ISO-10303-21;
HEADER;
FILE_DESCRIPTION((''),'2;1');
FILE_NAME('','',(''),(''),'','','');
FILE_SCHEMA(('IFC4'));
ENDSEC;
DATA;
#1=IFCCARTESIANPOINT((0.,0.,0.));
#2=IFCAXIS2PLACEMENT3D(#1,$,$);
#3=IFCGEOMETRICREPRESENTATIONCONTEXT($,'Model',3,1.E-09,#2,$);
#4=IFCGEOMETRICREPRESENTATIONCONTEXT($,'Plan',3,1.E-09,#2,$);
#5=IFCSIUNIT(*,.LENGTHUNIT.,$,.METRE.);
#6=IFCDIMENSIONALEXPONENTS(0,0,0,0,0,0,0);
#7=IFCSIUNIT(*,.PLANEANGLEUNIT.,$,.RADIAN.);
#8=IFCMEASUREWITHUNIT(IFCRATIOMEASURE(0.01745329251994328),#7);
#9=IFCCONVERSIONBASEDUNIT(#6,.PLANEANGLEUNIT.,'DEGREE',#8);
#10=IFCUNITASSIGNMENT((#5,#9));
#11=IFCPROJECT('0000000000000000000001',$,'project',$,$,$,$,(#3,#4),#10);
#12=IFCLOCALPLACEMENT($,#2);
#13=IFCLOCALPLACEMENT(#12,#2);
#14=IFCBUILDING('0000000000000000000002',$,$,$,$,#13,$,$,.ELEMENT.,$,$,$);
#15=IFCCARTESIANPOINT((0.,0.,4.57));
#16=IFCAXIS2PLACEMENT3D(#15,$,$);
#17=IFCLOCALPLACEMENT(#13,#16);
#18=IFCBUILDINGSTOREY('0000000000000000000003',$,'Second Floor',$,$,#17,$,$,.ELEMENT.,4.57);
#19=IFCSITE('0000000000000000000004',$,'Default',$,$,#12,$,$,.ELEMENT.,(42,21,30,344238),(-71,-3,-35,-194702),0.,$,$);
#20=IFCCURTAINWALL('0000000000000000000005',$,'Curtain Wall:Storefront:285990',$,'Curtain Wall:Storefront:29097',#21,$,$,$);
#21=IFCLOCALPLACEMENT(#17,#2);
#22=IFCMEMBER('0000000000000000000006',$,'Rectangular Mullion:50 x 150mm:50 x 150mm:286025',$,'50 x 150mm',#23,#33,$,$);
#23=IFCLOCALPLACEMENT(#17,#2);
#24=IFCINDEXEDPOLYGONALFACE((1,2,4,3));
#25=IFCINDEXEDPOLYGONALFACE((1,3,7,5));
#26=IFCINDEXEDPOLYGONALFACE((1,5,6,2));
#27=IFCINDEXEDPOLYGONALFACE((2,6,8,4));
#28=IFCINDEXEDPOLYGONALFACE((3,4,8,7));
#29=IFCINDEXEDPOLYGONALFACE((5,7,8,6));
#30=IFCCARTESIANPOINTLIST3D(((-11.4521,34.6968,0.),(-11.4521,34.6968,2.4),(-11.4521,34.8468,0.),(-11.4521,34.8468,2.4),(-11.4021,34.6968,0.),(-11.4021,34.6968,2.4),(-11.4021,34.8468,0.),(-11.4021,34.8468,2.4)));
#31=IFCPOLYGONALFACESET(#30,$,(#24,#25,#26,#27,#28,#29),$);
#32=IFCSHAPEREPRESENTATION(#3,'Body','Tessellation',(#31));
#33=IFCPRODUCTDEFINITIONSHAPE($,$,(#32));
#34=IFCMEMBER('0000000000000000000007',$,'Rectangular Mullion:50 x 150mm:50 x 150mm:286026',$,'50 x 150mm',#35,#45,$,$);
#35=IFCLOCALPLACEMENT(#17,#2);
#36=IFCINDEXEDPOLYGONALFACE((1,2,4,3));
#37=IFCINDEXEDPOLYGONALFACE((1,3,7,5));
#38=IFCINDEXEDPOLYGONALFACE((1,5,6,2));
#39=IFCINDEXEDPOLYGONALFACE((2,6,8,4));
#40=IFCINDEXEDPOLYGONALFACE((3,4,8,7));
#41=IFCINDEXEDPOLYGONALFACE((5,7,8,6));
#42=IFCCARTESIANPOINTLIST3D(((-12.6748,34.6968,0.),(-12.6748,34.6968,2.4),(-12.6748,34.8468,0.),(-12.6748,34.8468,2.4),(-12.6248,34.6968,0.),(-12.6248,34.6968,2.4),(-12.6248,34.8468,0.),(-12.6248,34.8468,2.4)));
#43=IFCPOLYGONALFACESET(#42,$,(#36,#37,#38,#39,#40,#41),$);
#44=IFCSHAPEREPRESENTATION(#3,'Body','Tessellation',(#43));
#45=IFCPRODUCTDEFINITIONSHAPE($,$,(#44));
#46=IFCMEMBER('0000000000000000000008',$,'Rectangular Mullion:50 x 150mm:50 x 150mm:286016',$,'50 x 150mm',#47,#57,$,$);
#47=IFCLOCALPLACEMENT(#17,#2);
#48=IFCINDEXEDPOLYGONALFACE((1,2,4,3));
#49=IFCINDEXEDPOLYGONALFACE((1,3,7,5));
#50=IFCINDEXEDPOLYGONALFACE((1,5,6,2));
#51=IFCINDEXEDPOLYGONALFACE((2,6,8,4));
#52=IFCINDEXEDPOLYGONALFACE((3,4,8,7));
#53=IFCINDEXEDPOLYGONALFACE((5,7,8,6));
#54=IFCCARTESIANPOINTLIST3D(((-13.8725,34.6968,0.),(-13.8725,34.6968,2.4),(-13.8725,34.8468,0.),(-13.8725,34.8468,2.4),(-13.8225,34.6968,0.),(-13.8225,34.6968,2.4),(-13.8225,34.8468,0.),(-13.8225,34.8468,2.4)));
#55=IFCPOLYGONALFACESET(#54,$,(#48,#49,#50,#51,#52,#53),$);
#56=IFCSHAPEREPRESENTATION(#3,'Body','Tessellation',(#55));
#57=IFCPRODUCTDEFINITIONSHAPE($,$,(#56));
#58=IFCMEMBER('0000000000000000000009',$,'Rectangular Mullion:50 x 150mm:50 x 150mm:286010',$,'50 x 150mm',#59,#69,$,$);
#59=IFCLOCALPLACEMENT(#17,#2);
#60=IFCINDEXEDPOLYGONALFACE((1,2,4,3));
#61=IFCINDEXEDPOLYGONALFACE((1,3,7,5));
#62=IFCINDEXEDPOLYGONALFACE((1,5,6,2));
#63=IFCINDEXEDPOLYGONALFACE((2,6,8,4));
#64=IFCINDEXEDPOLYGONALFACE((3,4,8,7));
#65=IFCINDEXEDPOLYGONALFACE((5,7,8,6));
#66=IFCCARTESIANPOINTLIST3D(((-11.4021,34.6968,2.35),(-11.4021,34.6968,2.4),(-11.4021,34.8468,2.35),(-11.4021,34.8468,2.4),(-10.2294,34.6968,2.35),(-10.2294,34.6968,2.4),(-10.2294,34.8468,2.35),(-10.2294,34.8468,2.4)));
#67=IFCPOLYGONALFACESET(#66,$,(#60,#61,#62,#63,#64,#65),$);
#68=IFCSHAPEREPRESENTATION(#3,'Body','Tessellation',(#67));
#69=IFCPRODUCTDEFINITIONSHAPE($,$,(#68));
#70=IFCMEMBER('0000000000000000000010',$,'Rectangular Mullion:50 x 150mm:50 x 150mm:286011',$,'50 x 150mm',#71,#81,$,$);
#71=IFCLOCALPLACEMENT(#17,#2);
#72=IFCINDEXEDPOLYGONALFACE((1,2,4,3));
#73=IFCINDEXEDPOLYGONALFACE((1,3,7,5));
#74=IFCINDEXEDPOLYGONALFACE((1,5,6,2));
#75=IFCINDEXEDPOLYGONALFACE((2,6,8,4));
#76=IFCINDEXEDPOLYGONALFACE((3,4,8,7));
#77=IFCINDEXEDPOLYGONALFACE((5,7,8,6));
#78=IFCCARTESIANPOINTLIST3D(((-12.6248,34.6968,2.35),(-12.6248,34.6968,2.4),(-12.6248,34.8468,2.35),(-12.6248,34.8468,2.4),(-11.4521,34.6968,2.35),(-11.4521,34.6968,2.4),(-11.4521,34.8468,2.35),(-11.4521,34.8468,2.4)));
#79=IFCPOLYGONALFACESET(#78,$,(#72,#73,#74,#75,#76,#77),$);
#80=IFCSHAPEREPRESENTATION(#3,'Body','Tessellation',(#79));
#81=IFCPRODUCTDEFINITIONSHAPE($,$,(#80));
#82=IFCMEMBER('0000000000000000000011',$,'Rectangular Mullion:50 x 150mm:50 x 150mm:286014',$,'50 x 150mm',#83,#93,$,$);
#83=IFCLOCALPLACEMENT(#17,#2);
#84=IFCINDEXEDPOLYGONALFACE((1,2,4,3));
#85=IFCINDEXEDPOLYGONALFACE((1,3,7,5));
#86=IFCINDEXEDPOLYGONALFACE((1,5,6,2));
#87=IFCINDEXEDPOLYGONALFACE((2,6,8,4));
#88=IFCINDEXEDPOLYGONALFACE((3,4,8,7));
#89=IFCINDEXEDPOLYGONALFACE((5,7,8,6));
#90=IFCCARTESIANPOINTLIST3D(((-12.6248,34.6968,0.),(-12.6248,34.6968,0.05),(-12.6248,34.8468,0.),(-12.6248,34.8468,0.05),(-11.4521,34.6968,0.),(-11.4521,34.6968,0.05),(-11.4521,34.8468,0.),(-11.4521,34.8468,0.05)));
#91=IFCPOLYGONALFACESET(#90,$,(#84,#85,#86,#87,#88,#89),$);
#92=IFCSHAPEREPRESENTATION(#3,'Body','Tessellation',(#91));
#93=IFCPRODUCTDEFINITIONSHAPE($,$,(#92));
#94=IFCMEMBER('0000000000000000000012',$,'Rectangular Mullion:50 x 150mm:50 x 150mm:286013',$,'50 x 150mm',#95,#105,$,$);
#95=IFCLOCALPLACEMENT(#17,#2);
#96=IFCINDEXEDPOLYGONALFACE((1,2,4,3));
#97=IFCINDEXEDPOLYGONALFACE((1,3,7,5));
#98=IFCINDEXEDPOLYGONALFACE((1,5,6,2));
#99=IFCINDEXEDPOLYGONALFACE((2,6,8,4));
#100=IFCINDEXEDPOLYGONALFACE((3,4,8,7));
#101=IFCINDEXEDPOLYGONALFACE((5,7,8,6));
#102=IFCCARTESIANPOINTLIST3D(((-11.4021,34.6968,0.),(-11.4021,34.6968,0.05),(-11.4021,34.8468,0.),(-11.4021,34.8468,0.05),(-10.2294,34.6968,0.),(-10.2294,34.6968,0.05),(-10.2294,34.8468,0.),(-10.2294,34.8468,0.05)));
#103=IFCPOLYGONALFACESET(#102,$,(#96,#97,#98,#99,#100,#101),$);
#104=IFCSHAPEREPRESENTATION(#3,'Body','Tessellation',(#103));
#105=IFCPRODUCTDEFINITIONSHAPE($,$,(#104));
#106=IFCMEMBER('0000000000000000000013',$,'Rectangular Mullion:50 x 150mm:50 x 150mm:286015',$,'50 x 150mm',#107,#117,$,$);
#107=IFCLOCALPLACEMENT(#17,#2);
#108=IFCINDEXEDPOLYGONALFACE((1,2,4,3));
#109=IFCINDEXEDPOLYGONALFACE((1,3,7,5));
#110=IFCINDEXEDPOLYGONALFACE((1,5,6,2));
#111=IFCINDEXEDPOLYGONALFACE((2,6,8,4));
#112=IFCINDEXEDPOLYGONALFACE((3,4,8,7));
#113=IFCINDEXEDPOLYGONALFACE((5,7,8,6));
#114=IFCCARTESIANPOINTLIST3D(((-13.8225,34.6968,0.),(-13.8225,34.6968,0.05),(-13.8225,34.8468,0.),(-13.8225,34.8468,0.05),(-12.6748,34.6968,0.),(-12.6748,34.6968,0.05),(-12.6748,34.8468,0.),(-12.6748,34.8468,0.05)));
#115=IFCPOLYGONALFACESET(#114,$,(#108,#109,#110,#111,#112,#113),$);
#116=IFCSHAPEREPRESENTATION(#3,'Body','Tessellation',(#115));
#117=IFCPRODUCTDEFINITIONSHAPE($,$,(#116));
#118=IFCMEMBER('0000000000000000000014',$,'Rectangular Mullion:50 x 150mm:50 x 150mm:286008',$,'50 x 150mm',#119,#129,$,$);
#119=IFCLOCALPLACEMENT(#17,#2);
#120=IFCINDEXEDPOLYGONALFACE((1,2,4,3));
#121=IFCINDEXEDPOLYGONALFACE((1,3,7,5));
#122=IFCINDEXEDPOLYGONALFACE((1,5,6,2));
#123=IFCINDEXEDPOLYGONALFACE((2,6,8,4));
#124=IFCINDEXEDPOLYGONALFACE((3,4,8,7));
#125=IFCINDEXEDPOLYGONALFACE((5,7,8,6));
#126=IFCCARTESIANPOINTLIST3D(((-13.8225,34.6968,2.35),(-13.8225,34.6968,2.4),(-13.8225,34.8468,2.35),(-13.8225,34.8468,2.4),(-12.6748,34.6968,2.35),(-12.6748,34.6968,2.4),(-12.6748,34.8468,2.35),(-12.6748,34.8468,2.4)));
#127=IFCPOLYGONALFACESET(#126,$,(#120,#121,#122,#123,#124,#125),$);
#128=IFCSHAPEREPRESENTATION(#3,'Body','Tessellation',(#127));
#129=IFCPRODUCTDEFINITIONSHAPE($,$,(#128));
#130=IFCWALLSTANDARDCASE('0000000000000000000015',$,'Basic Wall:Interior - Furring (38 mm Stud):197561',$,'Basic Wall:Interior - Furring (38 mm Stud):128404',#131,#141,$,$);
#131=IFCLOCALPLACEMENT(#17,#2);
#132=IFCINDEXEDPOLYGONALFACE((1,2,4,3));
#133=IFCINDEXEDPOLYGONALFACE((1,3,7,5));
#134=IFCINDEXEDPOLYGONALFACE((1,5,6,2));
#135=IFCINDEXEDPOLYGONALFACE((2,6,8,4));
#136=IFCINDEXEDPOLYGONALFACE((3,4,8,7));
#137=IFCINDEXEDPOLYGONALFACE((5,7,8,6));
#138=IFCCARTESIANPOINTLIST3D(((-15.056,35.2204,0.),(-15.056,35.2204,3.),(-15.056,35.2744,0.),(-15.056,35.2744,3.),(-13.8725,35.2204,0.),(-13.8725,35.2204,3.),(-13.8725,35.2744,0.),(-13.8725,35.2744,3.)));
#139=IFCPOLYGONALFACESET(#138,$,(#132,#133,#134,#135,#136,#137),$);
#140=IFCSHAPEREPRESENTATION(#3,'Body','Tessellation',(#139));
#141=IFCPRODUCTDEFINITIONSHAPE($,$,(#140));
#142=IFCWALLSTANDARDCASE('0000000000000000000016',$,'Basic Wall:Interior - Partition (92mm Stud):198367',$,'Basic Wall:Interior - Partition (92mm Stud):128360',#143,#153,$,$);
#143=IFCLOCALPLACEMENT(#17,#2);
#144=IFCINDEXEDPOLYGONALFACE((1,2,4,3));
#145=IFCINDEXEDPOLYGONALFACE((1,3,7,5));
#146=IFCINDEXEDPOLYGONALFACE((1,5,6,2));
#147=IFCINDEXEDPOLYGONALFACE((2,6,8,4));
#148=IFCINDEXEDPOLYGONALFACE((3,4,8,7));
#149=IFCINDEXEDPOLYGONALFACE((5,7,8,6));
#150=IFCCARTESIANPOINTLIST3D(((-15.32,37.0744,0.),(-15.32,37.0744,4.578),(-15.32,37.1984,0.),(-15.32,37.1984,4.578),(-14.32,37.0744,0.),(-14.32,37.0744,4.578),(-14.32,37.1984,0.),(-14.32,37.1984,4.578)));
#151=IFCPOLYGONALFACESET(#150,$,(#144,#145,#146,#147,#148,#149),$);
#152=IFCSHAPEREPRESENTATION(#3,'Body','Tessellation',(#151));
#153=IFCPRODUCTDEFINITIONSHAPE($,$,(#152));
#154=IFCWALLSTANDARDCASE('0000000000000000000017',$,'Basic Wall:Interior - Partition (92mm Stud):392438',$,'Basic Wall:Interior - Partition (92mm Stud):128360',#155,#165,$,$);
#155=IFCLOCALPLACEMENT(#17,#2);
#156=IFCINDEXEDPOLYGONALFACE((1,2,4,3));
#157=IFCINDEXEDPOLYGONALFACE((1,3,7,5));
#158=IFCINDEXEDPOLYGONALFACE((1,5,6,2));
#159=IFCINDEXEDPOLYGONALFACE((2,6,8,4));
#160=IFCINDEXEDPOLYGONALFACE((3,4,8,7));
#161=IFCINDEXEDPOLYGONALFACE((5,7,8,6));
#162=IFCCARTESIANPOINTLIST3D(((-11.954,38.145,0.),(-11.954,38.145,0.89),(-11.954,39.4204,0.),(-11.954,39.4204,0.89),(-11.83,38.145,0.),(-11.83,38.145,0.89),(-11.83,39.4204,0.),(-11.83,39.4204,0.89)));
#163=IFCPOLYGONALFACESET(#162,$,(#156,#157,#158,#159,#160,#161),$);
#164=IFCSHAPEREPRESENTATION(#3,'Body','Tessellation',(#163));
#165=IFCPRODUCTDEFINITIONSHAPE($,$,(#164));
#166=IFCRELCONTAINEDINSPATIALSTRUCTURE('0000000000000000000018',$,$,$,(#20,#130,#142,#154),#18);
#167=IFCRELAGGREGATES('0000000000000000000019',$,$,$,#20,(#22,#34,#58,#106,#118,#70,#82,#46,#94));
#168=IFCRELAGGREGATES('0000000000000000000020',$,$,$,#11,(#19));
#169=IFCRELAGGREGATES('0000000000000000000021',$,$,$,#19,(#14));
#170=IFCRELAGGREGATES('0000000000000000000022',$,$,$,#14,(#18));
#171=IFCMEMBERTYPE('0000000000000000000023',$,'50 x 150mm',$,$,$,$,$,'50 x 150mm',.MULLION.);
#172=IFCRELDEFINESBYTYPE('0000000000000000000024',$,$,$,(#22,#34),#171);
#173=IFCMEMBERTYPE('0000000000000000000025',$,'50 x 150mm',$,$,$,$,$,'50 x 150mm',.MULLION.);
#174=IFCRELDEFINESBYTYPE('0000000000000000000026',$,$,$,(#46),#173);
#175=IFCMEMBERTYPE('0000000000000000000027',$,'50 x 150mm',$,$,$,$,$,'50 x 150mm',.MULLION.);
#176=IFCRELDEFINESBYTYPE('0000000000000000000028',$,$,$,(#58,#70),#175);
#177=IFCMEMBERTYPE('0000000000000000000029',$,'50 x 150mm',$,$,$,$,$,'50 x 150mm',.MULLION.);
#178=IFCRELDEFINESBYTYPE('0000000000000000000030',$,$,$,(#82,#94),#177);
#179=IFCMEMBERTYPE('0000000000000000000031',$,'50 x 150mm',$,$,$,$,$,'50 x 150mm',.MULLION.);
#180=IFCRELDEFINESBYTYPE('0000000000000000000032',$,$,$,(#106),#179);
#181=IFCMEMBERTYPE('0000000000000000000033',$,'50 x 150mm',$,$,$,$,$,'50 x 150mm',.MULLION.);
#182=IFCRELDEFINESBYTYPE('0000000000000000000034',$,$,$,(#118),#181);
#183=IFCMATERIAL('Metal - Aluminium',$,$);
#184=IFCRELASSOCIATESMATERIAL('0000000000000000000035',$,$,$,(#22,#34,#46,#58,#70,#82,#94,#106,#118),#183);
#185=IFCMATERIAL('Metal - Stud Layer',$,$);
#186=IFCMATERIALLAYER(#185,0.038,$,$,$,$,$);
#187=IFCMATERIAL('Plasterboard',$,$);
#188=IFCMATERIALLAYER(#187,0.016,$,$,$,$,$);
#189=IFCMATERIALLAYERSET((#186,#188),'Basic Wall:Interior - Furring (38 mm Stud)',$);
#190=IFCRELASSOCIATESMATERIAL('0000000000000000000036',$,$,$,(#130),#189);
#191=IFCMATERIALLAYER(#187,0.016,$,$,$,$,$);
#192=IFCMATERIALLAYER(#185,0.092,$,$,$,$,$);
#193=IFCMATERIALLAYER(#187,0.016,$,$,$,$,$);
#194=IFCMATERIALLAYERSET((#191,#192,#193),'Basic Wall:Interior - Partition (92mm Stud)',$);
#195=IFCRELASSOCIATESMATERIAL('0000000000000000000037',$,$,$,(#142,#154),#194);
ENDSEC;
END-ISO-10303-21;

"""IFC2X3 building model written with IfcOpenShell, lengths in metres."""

from ifc_helpers import new_model, entity, si_unit, converted_unit, frame, frame_2d, origin, origin_2d_with_axis, place, context, project, spatial, rectangle, extrude, source, transform, mapped, material, layer, layer_set, layer_usage, type_object, type_shapes, element, aggregate, save


model = new_model("IFC2X3")

# Units and contexts
model_context = context("Model", 3, precision=1e-09, world=origin())
plan_context = context("Plan", 3, precision=1e-09, world=origin())
ifc_project = project(units=[si_unit("LENGTHUNIT", "METRE"), converted_unit("PLANEANGLEUNIT", "DEGREE", entity("IfcRatioMeasure", 0.01745329251994328), si_unit("PLANEANGLEUNIT", "RADIAN"), dimensions=[0, 0, 0, 0, 0, 0, 0])], contexts=[model_context, plan_context])

# Site, building, storey
site_placement = place(None, origin())
site = spatial("IfcSite", under=ifc_project, at=site_placement, Name="Default", CompositionType="ELEMENT", RefLatitude=(42, 21, 30, 344238), RefLongitude=(-71, -3, -35, -194702), RefElevation=0.0)
building_placement = place(site_placement, origin())
building = spatial("IfcBuilding", under=site, at=building_placement, CompositionType="ELEMENT")
storey_placement = place(building_placement, frame((0.0, 0.0, 4.57)))
storey = spatial("IfcBuildingStorey", under=building, at=storey_placement, Name="Second Floor", CompositionType="ELEMENT", Elevation=4.57)

# Curtain wall, members
curtain_wall_placement = place(storey_placement, origin())
curtain_wall = element("IfcCurtainWall", 1, at=curtain_wall_placement, inside=storey, Name="Curtain Wall:Storefront:285990", ObjectType="Curtain Wall:Storefront:29097")
ifc_material_1 = material(Name="Metal - Aluminium")
member_type_1 = type_object("IfcMemberType", Name="50 x 150mm", ElementType="50 x 150mm", PredefinedType="MULLION")
shared_shape_1 = source(origin(), model_context, "Body", "SweptSolid", [
    extrude(rectangle(XDim=0.05, YDim=0.15, at=origin_2d_with_axis()), frame((0.0, 0.0, -2.4), z_axis=(0.0, 0.0, 1.0), x_axis=(-1.0, 0.0, 0.0)), (0.0, 0.0, 1.0), 2.4),
])
type_shapes(member_type_1, [shared_shape_1])
member_1_placement = place(storey_placement, frame((-11.4271, 34.7718, 0.0), z_axis=(0.0, 0.0, -1.0), x_axis=(-1.0, 0.0, 0.0)))
member_1 = element("IfcMember", 2, at=member_1_placement, type_object=member_type_1, material=ifc_material_1, Name="Rectangular Mullion:50 x 150mm:50 x 150mm:286025", ObjectType="50 x 150mm", context=model_context, shape_type="MappedRepresentation", body=[
    mapped(shared_shape_1, transform((0.0, 0.0, 0.0), scale=1.0)),
])
member_2_placement = place(storey_placement, frame((-12.6498, 34.7718, 0.0), z_axis=(0.0, 0.0, -1.0), x_axis=(-1.0, 0.0, 0.0)))
member_2 = element("IfcMember", 3, at=member_2_placement, type_object=member_type_1, material=ifc_material_1, Name="Rectangular Mullion:50 x 150mm:50 x 150mm:286026", ObjectType="50 x 150mm", context=model_context, shape_type="MappedRepresentation", body=[
    mapped(shared_shape_1, transform((0.0, 0.0, 0.0), scale=1.0)),
])
member_type_2 = type_object("IfcMemberType", Name="50 x 150mm", ElementType="50 x 150mm", PredefinedType="MULLION")
shared_shape_2 = source(origin(), model_context, "Body", "SweptSolid", [
    extrude(rectangle(XDim=0.05, YDim=0.15, at=origin_2d_with_axis()), frame((-0.025, 0.0, -2.4), z_axis=(0.0, 0.0, 1.0), x_axis=(-1.0, 0.0, 0.0)), (0.0, 0.0, 1.0), 2.4),
])
type_shapes(member_type_2, [shared_shape_2])
member_3_placement = place(storey_placement, frame((-13.8725, 34.7718, 0.0), z_axis=(0.0, 0.0, -1.0), x_axis=(-1.0, 0.0, 0.0)))
member_3 = element("IfcMember", 4, at=member_3_placement, type_object=member_type_2, material=ifc_material_1, Name="Rectangular Mullion:50 x 150mm:50 x 150mm:286016", ObjectType="50 x 150mm", context=model_context, shape_type="MappedRepresentation", body=[
    mapped(shared_shape_2, transform((0.0, 0.0, 0.0), scale=1.0)),
])
member_type_3 = type_object("IfcMemberType", Name="50 x 150mm", ElementType="50 x 150mm", PredefinedType="MULLION")
shared_shape_3 = source(origin(), model_context, "Body", "SweptSolid", [
    extrude(rectangle(XDim=0.05, YDim=0.15, at=origin_2d_with_axis()), frame((-0.025, 0.0, -1.1727), z_axis=(0.0, 0.0, 1.0), x_axis=(-1.0, 0.0, 0.0)), (0.0, 0.0, 1.0), 1.1727),
])
type_shapes(member_type_3, [shared_shape_3])
member_4_placement = place(storey_placement, frame((-11.4021, 34.7718, 2.4), z_axis=(-1.0, 0.0, 0.0), x_axis=(0.0, 0.0, 1.0)))
member_4 = element("IfcMember", 5, at=member_4_placement, type_object=member_type_3, material=ifc_material_1, Name="Rectangular Mullion:50 x 150mm:50 x 150mm:286010", ObjectType="50 x 150mm", context=model_context, shape_type="MappedRepresentation", body=[
    mapped(shared_shape_3, transform((0.0, 0.0, 0.0), scale=1.0)),
])
member_5_placement = place(storey_placement, frame((-12.6248, 34.7718, 2.4), z_axis=(-1.0, 0.0, 0.0), x_axis=(0.0, 0.0, 1.0)))
member_5 = element("IfcMember", 6, at=member_5_placement, type_object=member_type_3, material=ifc_material_1, Name="Rectangular Mullion:50 x 150mm:50 x 150mm:286011", ObjectType="50 x 150mm", context=model_context, shape_type="MappedRepresentation", body=[
    mapped(shared_shape_3, transform((0.0, 0.0, 0.0), scale=1.0)),
])
member_type_4 = type_object("IfcMemberType", Name="50 x 150mm", ElementType="50 x 150mm", PredefinedType="MULLION")
type_shapes(member_type_4, [shared_shape_3])
member_6_placement = place(storey_placement, frame((-11.4521, 34.7718, 0.0), z_axis=(1.0, 0.0, 0.0), x_axis=(0.0, 0.0, -1.0)))
member_6 = element("IfcMember", 7, at=member_6_placement, type_object=member_type_4, material=ifc_material_1, Name="Rectangular Mullion:50 x 150mm:50 x 150mm:286014", ObjectType="50 x 150mm", context=model_context, shape_type="MappedRepresentation", body=[
    mapped(shared_shape_3, transform((0.0, 0.0, 0.0), scale=1.0)),
])
member_7_placement = place(storey_placement, frame((-10.2294, 34.7718, 0.0), z_axis=(1.0, 0.0, 0.0), x_axis=(0.0, 0.0, -1.0)))
member_7 = element("IfcMember", 8, at=member_7_placement, type_object=member_type_4, material=ifc_material_1, Name="Rectangular Mullion:50 x 150mm:50 x 150mm:286013", ObjectType="50 x 150mm", context=model_context, shape_type="MappedRepresentation", body=[
    mapped(shared_shape_3, transform((0.0, 0.0, 0.0), scale=1.0)),
])
member_type_5 = type_object("IfcMemberType", Name="50 x 150mm", ElementType="50 x 150mm", PredefinedType="MULLION")
shared_shape_4 = source(origin(), model_context, "Body", "SweptSolid", [
    extrude(rectangle(XDim=0.05, YDim=0.15, at=origin_2d_with_axis()), frame((-0.025, 0.0, -1.1477), z_axis=(0.0, 0.0, 1.0), x_axis=(-1.0, 0.0, 0.0)), (0.0, 0.0, 1.0), 1.1477),
])
type_shapes(member_type_5, [shared_shape_4])
member_8_placement = place(storey_placement, frame((-12.6748, 34.7718, 0.0), z_axis=(1.0, 0.0, 0.0), x_axis=(0.0, 0.0, -1.0)))
member_8 = element("IfcMember", 9, at=member_8_placement, type_object=member_type_5, material=ifc_material_1, Name="Rectangular Mullion:50 x 150mm:50 x 150mm:286015", ObjectType="50 x 150mm", context=model_context, shape_type="MappedRepresentation", body=[
    mapped(shared_shape_4, transform((0.0, 0.0, 0.0), scale=1.0)),
])
member_type_6 = type_object("IfcMemberType", Name="50 x 150mm", ElementType="50 x 150mm", PredefinedType="MULLION")
shared_shape_5 = source(origin(), model_context, "Body", "SweptSolid", [
    extrude(rectangle(XDim=0.05, YDim=0.15, at=origin_2d_with_axis()), frame((-0.025, 0.0, -1.1477), z_axis=(0.0, 0.0, 1.0), x_axis=(-1.0, 0.0, 0.0)), (0.0, 0.0, 1.0), 1.1477),
])
type_shapes(member_type_6, [shared_shape_5])
member_9_placement = place(storey_placement, frame((-13.8225, 34.7718, 2.4), z_axis=(-1.0, 0.0, 0.0), x_axis=(0.0, 0.0, 1.0)))
member_9 = element("IfcMember", 10, at=member_9_placement, type_object=member_type_6, material=ifc_material_1, Name="Rectangular Mullion:50 x 150mm:50 x 150mm:286008", ObjectType="50 x 150mm", context=model_context, shape_type="MappedRepresentation", body=[
    mapped(shared_shape_5, transform((0.0, 0.0, 0.0), scale=1.0)),
])
aggregate(curtain_wall, [member_1, member_2, member_4, member_8, member_9, member_5, member_6, member_3, member_7])

# Shared definitions
ifc_material_2 = material(Name="Plasterboard")
ifc_layer_1 = layer(ifc_material_2, 0.016)
ifc_material_3 = material(Name="Metal - Stud Layer")
ifc_layer_2 = layer(ifc_material_3, 0.092)
ifc_layer_3 = layer(ifc_material_2, 0.016)
ifc_layer_set_1 = layer_set([ifc_layer_1, ifc_layer_2, ifc_layer_3], Name="Basic Wall:Interior - Partition (92mm Stud)")
ifc_layer_usage_1 = layer_usage(ifc_layer_set_1, "AXIS2", "NEGATIVE", 0.062)

# Walls
ifc_layer_4 = layer(ifc_material_3, 0.038)
ifc_layer_5 = layer(ifc_material_2, 0.016)
ifc_layer_set_2 = layer_set([ifc_layer_4, ifc_layer_5], Name="Basic Wall:Interior - Furring (38 mm Stud)")
ifc_layer_usage_2 = layer_usage(ifc_layer_set_2, "AXIS2", "POSITIVE", -0.027)
wall_1_placement = place(storey_placement, frame((-15.056, 35.2474, 0.0)))
element("IfcWallStandardCase", 11, at=wall_1_placement, inside=storey, material=ifc_layer_usage_2, Name="Basic Wall:Interior - Furring (38 mm Stud):197561", ObjectType="Basic Wall:Interior - Furring (38 mm Stud):128404", context=model_context, shape_type="SweptSolid", body=[
    extrude(rectangle(XDim=1.1835, YDim=0.054, at=frame_2d((0.5917, 0.0), x_axis=(-1.0, 0.0))), origin(), (0.0, 0.0, 1.0), 3.0),
])
wall_2_placement = place(storey_placement, frame((-14.32, 37.1364, 0.0), z_axis=(0.0, 0.0, 1.0), x_axis=(-1.0, 0.0, 0.0)))
element("IfcWallStandardCase", 12, at=wall_2_placement, inside=storey, material=ifc_layer_usage_1, Name="Basic Wall:Interior - Partition (92mm Stud):198367", ObjectType="Basic Wall:Interior - Partition (92mm Stud):128360", context=model_context, shape_type="SweptSolid", body=[
    extrude(rectangle(XDim=1.0, YDim=0.124, at=frame_2d((0.5, 0.0), x_axis=(-1.0, 0.0))), origin(), (0.0, 0.0, 1.0), 4.578),
])
ifc_layer_usage_3 = layer_usage(ifc_layer_set_1, "AXIS2", "POSITIVE", -0.062)
wall_3_placement = place(storey_placement, frame((-11.892, 38.145, 0.0), z_axis=(0.0, 0.0, 1.0), x_axis=(0.0, 1.0, 0.0)))
element("IfcWallStandardCase", 13, at=wall_3_placement, inside=storey, material=ifc_layer_usage_3, Name="Basic Wall:Interior - Partition (92mm Stud):392438", ObjectType="Basic Wall:Interior - Partition (92mm Stud):128360", context=model_context, shape_type="SweptSolid", body=[
    extrude(rectangle(XDim=1.2755, YDim=0.124, at=frame_2d((0.6377, 0.0), x_axis=(-1.0, 0.0))), origin(), (0.0, 0.0, 1.0), 0.89),
])

save(model, "model.ifc")
